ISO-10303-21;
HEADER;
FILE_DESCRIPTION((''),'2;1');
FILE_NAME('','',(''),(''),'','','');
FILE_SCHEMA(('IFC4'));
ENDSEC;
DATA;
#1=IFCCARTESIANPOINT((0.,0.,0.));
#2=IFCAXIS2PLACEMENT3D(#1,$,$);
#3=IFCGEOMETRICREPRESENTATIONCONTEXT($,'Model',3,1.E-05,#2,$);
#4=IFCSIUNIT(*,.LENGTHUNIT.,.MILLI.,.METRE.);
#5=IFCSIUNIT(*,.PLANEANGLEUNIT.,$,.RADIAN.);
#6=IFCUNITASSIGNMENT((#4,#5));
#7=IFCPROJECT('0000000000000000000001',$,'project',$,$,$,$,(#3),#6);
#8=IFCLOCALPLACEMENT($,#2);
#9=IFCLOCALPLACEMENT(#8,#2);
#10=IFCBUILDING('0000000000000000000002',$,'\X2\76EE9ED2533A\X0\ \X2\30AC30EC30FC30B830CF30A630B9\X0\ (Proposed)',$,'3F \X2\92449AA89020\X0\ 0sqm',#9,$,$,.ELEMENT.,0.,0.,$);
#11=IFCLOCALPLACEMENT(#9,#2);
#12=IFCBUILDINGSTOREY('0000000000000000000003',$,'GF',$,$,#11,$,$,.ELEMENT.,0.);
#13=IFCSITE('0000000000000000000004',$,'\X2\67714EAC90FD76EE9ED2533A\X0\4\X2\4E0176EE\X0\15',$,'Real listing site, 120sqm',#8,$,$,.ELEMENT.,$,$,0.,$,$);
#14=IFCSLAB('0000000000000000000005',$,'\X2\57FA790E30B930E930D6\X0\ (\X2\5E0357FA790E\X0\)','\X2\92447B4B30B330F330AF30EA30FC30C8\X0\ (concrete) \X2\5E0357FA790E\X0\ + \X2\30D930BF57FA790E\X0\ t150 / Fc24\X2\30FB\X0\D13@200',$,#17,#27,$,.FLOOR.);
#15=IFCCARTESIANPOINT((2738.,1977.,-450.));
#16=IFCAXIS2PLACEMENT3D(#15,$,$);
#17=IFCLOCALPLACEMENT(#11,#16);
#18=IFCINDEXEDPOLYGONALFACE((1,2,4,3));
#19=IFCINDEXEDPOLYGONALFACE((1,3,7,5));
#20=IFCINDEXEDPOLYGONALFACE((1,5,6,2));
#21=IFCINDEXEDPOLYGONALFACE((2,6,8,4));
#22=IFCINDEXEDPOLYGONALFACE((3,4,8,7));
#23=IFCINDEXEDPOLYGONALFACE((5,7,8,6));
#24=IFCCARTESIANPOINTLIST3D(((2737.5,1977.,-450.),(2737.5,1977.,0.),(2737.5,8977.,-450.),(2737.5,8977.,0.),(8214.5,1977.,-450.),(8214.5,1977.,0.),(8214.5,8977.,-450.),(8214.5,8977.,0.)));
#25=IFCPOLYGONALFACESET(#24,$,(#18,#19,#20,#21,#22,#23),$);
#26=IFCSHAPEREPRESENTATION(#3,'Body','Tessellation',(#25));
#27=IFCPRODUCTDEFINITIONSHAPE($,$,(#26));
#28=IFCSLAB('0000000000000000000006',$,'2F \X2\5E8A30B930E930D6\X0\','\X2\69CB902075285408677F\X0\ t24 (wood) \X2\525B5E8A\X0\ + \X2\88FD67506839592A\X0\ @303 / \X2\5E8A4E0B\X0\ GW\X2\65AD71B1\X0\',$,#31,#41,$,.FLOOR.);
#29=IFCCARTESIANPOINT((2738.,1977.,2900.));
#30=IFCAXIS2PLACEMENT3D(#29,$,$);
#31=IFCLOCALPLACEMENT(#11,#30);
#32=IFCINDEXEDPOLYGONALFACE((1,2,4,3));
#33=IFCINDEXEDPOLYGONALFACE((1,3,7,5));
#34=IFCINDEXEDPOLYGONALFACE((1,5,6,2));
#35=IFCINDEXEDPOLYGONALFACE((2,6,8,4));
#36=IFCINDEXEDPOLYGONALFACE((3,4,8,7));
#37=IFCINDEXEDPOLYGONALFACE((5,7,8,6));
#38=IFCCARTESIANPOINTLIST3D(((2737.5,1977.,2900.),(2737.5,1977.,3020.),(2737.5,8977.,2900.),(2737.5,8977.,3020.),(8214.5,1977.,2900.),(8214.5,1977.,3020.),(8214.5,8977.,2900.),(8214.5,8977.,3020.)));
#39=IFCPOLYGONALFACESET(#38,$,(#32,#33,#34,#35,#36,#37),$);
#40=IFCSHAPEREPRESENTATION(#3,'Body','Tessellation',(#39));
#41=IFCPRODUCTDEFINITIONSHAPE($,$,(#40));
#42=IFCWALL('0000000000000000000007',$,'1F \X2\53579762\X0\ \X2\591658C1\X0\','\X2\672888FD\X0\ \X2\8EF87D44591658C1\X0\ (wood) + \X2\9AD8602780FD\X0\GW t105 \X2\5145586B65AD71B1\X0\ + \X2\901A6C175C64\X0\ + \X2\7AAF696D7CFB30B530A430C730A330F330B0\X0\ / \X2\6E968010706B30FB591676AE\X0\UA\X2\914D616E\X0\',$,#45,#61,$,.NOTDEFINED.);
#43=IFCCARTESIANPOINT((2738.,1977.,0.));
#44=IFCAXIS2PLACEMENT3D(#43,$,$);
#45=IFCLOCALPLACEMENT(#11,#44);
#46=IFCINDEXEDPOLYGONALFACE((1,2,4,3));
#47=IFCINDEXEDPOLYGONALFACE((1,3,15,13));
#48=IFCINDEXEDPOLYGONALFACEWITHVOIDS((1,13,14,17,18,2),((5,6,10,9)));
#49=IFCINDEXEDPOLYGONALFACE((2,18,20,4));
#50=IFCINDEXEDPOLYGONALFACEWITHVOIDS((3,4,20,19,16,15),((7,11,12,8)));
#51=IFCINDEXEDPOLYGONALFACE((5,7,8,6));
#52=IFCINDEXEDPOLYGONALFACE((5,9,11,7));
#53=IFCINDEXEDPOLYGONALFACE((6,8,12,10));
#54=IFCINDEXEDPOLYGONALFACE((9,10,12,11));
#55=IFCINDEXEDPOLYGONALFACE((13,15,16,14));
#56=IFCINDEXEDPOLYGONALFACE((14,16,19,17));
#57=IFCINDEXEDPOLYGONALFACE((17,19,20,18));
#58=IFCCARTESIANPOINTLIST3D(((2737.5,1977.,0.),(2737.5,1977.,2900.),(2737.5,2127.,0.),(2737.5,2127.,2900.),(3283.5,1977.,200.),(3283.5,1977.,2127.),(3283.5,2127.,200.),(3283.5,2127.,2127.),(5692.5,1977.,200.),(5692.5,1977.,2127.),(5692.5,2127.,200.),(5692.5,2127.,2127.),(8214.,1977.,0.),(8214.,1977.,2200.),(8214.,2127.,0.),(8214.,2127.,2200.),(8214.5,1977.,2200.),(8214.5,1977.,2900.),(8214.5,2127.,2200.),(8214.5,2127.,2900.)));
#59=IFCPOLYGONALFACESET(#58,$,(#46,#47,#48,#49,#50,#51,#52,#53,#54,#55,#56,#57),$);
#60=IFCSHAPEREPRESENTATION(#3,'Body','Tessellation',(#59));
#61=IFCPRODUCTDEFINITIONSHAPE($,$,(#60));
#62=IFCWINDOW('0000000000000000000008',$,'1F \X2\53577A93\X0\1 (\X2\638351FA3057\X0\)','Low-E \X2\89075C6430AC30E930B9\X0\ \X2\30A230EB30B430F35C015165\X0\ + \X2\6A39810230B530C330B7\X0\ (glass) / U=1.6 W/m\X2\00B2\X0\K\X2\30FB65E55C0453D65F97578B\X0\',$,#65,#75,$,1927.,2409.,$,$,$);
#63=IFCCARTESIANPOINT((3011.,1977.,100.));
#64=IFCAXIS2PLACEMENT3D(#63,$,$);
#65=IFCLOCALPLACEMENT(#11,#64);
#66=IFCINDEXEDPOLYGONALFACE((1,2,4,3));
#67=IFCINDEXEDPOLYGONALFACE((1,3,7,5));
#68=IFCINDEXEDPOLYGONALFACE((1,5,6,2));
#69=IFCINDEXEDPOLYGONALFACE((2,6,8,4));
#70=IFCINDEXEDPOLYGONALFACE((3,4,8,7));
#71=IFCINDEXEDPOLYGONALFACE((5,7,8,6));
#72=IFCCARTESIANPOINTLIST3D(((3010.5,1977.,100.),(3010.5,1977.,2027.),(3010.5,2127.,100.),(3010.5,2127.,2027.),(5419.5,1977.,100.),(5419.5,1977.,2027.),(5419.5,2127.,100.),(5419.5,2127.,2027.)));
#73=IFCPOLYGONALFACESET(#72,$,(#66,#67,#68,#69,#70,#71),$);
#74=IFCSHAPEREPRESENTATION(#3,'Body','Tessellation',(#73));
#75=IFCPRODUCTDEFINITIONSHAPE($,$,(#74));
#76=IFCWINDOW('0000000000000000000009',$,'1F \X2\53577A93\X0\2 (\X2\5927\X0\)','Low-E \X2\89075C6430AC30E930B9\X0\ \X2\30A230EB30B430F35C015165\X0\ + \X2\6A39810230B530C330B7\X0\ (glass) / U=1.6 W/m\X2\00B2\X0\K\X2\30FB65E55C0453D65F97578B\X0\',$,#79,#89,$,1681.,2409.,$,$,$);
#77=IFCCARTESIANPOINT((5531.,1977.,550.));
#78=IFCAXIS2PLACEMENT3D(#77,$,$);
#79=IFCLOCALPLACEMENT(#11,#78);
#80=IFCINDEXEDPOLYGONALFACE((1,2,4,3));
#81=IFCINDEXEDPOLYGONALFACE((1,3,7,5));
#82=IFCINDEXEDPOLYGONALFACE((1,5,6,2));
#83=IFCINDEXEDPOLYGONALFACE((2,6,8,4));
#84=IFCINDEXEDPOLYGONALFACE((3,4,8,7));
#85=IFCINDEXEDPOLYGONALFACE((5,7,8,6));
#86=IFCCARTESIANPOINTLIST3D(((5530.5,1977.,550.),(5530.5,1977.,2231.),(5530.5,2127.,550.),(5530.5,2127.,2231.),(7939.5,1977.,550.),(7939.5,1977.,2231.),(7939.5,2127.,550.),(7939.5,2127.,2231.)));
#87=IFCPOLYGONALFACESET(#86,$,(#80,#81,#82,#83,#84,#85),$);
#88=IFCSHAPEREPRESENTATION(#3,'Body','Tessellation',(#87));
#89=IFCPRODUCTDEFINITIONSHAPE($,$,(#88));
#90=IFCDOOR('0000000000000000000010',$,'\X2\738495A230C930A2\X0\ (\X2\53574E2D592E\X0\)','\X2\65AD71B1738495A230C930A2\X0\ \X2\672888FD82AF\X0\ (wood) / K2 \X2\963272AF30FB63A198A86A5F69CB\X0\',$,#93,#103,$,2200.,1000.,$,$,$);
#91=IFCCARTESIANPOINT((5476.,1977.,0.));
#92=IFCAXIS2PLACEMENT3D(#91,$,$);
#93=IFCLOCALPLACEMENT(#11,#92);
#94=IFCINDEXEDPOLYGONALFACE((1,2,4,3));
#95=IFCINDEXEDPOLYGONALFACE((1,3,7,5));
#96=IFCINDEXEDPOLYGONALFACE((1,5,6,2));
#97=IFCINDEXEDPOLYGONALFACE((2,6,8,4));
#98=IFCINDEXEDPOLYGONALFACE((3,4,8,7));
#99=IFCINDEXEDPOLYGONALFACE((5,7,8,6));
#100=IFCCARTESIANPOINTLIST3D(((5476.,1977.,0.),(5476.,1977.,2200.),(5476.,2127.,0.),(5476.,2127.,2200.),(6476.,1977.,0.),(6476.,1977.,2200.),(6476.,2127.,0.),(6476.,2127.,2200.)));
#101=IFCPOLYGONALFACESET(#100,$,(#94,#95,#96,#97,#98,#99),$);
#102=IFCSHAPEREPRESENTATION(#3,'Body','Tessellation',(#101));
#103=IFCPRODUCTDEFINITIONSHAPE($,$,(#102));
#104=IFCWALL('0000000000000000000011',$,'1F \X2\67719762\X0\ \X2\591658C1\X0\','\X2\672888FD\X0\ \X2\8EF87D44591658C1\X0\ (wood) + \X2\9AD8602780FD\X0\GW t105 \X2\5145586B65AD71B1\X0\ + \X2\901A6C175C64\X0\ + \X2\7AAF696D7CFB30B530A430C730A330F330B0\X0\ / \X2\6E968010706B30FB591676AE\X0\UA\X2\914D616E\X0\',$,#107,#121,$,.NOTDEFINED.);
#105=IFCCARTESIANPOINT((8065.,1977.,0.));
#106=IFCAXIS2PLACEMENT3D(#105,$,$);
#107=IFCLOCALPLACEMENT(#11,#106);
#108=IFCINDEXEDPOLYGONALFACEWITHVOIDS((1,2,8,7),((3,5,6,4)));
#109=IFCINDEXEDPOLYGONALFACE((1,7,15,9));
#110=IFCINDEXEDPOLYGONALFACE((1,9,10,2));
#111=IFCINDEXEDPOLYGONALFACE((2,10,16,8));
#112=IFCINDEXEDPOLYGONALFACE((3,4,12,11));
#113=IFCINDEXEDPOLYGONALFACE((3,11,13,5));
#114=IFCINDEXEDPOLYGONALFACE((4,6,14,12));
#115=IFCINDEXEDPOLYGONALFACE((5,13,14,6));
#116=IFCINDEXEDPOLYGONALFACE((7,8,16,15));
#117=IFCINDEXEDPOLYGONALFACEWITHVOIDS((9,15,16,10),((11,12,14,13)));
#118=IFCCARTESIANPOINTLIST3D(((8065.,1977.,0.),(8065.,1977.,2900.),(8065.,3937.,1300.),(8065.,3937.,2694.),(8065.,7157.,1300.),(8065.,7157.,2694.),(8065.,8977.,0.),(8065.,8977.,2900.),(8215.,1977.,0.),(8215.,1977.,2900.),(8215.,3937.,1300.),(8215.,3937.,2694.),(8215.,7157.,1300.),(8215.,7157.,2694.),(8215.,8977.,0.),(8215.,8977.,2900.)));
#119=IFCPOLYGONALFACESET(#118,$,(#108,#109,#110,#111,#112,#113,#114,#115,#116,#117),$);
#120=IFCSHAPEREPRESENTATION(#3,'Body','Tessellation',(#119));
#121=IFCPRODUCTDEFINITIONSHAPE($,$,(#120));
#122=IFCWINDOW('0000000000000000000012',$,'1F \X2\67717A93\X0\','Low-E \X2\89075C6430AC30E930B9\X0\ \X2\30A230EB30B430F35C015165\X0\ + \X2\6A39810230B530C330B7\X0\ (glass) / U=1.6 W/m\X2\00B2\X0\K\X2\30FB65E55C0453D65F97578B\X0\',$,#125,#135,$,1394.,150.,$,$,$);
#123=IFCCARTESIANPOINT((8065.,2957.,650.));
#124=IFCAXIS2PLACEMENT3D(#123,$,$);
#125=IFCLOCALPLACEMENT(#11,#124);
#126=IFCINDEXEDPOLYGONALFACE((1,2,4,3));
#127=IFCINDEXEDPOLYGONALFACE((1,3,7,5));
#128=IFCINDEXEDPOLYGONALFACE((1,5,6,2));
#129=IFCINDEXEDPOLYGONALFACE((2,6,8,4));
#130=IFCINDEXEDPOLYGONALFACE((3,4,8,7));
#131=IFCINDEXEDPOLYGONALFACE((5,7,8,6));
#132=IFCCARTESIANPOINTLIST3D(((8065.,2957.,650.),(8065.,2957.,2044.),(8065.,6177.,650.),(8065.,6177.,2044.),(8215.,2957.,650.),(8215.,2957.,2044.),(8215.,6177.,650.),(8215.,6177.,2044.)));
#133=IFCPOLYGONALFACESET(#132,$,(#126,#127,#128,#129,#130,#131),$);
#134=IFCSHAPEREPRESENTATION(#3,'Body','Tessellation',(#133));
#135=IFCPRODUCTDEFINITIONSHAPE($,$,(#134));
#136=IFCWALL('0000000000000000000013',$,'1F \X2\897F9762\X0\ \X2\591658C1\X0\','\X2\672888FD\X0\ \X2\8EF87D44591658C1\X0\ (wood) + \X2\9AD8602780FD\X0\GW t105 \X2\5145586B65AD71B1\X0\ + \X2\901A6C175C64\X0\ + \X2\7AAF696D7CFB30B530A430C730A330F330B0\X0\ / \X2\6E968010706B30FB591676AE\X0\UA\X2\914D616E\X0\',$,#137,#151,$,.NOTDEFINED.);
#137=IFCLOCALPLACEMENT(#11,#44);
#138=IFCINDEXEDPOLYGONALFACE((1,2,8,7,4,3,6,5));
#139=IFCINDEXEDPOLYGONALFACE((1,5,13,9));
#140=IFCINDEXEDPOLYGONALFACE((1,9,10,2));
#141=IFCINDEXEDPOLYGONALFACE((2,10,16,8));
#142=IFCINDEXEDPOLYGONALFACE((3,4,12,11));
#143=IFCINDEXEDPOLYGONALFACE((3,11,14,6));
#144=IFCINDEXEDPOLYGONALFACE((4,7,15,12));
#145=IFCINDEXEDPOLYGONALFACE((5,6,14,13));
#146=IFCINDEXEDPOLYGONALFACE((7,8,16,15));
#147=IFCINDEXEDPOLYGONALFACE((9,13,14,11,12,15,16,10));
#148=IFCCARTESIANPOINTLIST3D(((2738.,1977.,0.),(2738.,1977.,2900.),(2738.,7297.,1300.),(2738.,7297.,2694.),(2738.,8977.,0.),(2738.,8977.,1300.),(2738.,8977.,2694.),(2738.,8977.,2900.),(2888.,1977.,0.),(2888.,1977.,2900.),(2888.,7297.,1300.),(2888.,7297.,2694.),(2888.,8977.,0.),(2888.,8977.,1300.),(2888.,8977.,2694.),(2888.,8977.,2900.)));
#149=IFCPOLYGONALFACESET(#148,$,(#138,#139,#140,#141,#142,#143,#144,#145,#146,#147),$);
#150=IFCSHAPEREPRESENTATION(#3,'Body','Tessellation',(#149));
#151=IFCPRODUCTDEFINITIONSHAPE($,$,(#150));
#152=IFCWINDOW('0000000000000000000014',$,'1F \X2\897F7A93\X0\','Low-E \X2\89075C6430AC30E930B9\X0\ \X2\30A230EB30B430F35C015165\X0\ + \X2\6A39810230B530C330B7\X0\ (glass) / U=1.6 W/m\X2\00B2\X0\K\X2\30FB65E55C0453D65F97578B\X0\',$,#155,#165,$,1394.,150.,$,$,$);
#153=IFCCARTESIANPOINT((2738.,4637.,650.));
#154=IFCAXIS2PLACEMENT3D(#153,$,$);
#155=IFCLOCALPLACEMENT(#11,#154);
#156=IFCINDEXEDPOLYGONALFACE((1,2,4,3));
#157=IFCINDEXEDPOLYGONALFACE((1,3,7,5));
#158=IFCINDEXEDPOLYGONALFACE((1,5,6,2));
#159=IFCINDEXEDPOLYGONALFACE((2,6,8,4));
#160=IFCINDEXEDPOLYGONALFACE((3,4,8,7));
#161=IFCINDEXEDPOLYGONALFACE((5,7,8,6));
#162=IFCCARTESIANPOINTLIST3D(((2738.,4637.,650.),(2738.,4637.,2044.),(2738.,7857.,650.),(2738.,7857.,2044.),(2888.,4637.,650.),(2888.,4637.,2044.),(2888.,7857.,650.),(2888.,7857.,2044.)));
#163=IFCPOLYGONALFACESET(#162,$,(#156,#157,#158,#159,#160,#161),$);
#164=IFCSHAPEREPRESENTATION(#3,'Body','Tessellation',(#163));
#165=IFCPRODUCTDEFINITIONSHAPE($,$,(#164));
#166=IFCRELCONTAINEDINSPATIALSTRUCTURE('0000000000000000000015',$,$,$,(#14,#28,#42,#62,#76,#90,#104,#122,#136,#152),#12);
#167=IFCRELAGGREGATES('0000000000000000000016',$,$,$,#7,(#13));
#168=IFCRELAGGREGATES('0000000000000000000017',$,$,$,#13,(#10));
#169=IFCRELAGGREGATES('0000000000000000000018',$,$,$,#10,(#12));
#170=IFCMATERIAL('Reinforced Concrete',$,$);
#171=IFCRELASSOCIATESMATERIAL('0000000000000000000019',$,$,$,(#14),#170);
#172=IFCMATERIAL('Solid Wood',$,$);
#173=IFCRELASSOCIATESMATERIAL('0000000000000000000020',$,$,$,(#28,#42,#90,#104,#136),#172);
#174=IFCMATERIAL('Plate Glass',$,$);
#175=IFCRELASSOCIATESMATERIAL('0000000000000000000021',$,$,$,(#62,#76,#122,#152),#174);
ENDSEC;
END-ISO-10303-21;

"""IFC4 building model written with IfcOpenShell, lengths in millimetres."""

from ifc_helpers import new_model, si_unit, frame, frame_2d, origin, place, context, project, spatial, rectangle, extrude, material, element, fill, save


model = new_model("IFC4")

# Units and contexts
model_context = context("Model", 3, precision=1e-05, world=origin())
ifc_project = project(units=[si_unit("LENGTHUNIT", "METRE", prefix="MILLI"), si_unit("PLANEANGLEUNIT", "RADIAN")], contexts=[model_context])

# Site, building, storey
site_placement = place(None, origin())
site = spatial("IfcSite", under=ifc_project, at=site_placement, Name="東京都目黒区4丁目15", ObjectType="Real listing site, 120sqm", CompositionType="ELEMENT", RefElevation=0.0)
building_placement = place(site_placement, origin())
building = spatial("IfcBuilding", under=site, at=building_placement, Name="目黒区 ガレージハウス (Proposed)", ObjectType="3F 鉄骨造 0sqm", CompositionType="ELEMENT", ElevationOfRefHeight=0.0, ElevationOfTerrain=0.0)
storey_placement = place(building_placement, origin())
storey = spatial("IfcBuildingStorey", under=building, at=storey_placement, Name="GF", CompositionType="ELEMENT", Elevation=0.0)

# Slabs
ifc_material_1 = material(Name="Reinforced Concrete")
slab_1_placement = place(storey_placement, frame((2738.0, 1977.0, -450.0)))
element("IfcSlab", 1, at=slab_1_placement, inside=storey, material=ifc_material_1, Name="基礎スラブ (布基礎)", Description="鉄筋コンクリート (concrete) 布基礎 + ベタ基礎 t150 / Fc24・D13@200", PredefinedType="FLOOR", context=model_context, shape_type="SweptSolid", body=[
    extrude(rectangle(XDim=5477.0, YDim=7000.0, at=frame_2d((2738.0, 3500.0))), frame((2738.0, 1977.0, -450.0)), (0.0, 0.0, 1.0), 450.0),
])
ifc_material_2 = material(Name="Solid Wood")
slab_2_placement = place(storey_placement, frame((2738.0, 1977.0, 2900.0)))
element("IfcSlab", 2, at=slab_2_placement, inside=storey, material=ifc_material_2, Name="2F 床スラブ", Description="構造用合板 t24 (wood) 剛床 + 製材根太 @303 / 床下 GW断熱", PredefinedType="FLOOR", context=model_context, shape_type="SweptSolid", body=[
    extrude(rectangle(XDim=5477.0, YDim=7000.0, at=frame_2d((2738.0, 3500.0))), frame((2738.0, 1977.0, 2900.0)), (0.0, 0.0, 1.0), 120.0),
])

# Wall, openings, windows, door
wall_1_placement = place(storey_placement, frame((2738.0, 1977.0, 0.0)))
wall_1 = element("IfcWall", 3, at=wall_1_placement, inside=storey, material=ifc_material_2, Name="1F 南面 外壁", Description="木製 軸組外壁 (wood) + 高性能GW t105 充填断熱 + 通気層 + 窯業系サイディング / 準耐火・外皮UA配慮", PredefinedType="NOTDEFINED", context=model_context, shape_type="SweptSolid", body=[
    extrude(rectangle(XDim=5477.0, YDim=150.0, at=frame_2d((2738.0, 75.0))), frame((2738.0, 1977.0, 0.0)), (0.0, 0.0, 1.0), 2900.0),
])
opening_1_placement = place(storey_placement, frame((3011.0, 1977.0, 100.0)))
opening_1 = element("IfcOpeningElement", 4, at=opening_1_placement, cuts=wall_1, PredefinedType="NOTDEFINED", context=model_context, shape_type="SweptSolid", body=[
    extrude(rectangle(XDim=2409.0, YDim=150.0, at=frame_2d((1204.0, 75.0))), frame((3011.0, 1977.0, 100.0)), (0.0, 0.0, 1.0), 1927.0),
])
opening_2_placement = place(storey_placement, frame((5531.0, 1977.0, 550.0)))
opening_2 = element("IfcOpeningElement", 5, at=opening_2_placement, cuts=wall_1, PredefinedType="NOTDEFINED", context=model_context, shape_type="SweptSolid", body=[
    extrude(rectangle(XDim=2409.0, YDim=150.0, at=frame_2d((1204.0, 75.0))), frame((5531.0, 1977.0, 550.0)), (0.0, 0.0, 1.0), 1681.0),
])
opening_3_placement = place(storey_placement, frame((5476.0, 1977.0, 0.0)))
opening_3 = element("IfcOpeningElement", 6, at=opening_3_placement, cuts=wall_1, PredefinedType="NOTDEFINED", context=model_context, shape_type="SweptSolid", body=[
    extrude(rectangle(XDim=1000.0, YDim=150.0, at=frame_2d((500.0, 75.0))), frame((5476.0, 1977.0, 0.0)), (0.0, 0.0, 1.0), 2200.0),
])
ifc_material_3 = material(Name="Plate Glass")
window_1_placement = place(storey_placement, frame((3011.0, 1977.0, 100.0)))
window_1 = element("IfcWindow", 7, at=window_1_placement, inside=storey, material=ifc_material_3, Name="1F 南窓1 (掃出し)", Description="Low-E 複層ガラス アルゴン封入 + 樹脂サッシ (glass) / U=1.6 W/m²K・日射取得型", OverallHeight=1927.0, OverallWidth=2409.0, context=model_context, shape_type="SweptSolid", body=[
    extrude(rectangle(XDim=2409.0, YDim=150.0, at=frame_2d((1204.0, 75.0))), frame((3011.0, 1977.0, 100.0)), (0.0, 0.0, 1.0), 1927.0),
])
fill(opening_1, window_1)
window_2_placement = place(storey_placement, frame((5531.0, 1977.0, 550.0)))
window_2 = element("IfcWindow", 8, at=window_2_placement, inside=storey, material=ifc_material_3, Name="1F 南窓2 (大)", Description="Low-E 複層ガラス アルゴン封入 + 樹脂サッシ (glass) / U=1.6 W/m²K・日射取得型", OverallHeight=1681.0, OverallWidth=2409.0, context=model_context, shape_type="SweptSolid", body=[
    extrude(rectangle(XDim=2409.0, YDim=150.0, at=frame_2d((1204.0, 75.0))), frame((5531.0, 1977.0, 550.0)), (0.0, 0.0, 1.0), 1681.0),
])
fill(opening_2, window_2)
door_placement = place(storey_placement, frame((5476.0, 1977.0, 0.0)))
door = element("IfcDoor", 9, at=door_placement, inside=storey, material=ifc_material_2, Name="玄関ドア (南中央)", Description="断熱玄関ドア 木製芯 (wood) / K2 防犯・採風機構", OverallHeight=2200.0, OverallWidth=1000.0, context=model_context, shape_type="SweptSolid", body=[
    extrude(rectangle(XDim=1000.0, YDim=150.0, at=frame_2d((500.0, 75.0))), frame((5476.0, 1977.0, 0.0)), (0.0, 0.0, 1.0), 2200.0),
])
fill(opening_3, door)

# Walls, openings, windows
wall_2_placement = place(storey_placement, frame((8065.0, 1977.0, 0.0)))
wall_2 = element("IfcWall", 10, at=wall_2_placement, inside=storey, material=ifc_material_2, Name="1F 東面 外壁", Description="木製 軸組外壁 (wood) + 高性能GW t105 充填断熱 + 通気層 + 窯業系サイディング / 準耐火・外皮UA配慮", PredefinedType="NOTDEFINED", context=model_context, shape_type="SweptSolid", body=[
    extrude(rectangle(XDim=150.0, YDim=7000.0, at=frame_2d((75.0, 3500.0))), frame((8065.0, 1977.0, 0.0)), (0.0, 0.0, 1.0), 2900.0),
])
opening_4_placement = place(storey_placement, frame((8065.0, 2957.0, 650.0)))
opening_4 = element("IfcOpeningElement", 11, at=opening_4_placement, cuts=wall_2, PredefinedType="NOTDEFINED", context=model_context, shape_type="SweptSolid", body=[
    extrude(rectangle(XDim=150.0, YDim=3220.0, at=frame_2d((75.0, 1610.0))), frame((8065.0, 2957.0, 650.0)), (0.0, 0.0, 1.0), 1394.0),
])
window_3_placement = place(storey_placement, frame((8065.0, 2957.0, 650.0)))
window_3 = element("IfcWindow", 12, at=window_3_placement, inside=storey, material=ifc_material_3, Name="1F 東窓", Description="Low-E 複層ガラス アルゴン封入 + 樹脂サッシ (glass) / U=1.6 W/m²K・日射取得型", OverallHeight=1394.0, OverallWidth=150.0, context=model_context, shape_type="SweptSolid", body=[
    extrude(rectangle(XDim=150.0, YDim=3220.0, at=frame_2d((75.0, 1610.0))), frame((8065.0, 2957.0, 650.0)), (0.0, 0.0, 1.0), 1394.0),
])
fill(opening_4, window_3)
wall_3_placement = place(storey_placement, frame((2738.0, 1977.0, 0.0)))
wall_3 = element("IfcWall", 13, at=wall_3_placement, inside=storey, material=ifc_material_2, Name="1F 西面 外壁", Description="木製 軸組外壁 (wood) + 高性能GW t105 充填断熱 + 通気層 + 窯業系サイディング / 準耐火・外皮UA配慮", PredefinedType="NOTDEFINED", context=model_context, shape_type="SweptSolid", body=[
    extrude(rectangle(XDim=150.0, YDim=7000.0, at=frame_2d((75.0, 3500.0))), frame((2738.0, 1977.0, 0.0)), (0.0, 0.0, 1.0), 2900.0),
])
opening_5_placement = place(storey_placement, frame((2738.0, 4637.0, 650.0)))
opening_5 = element("IfcOpeningElement", 14, at=opening_5_placement, cuts=wall_3, PredefinedType="NOTDEFINED", context=model_context, shape_type="SweptSolid", body=[
    extrude(rectangle(XDim=150.0, YDim=3220.0, at=frame_2d((75.0, 1610.0))), frame((2738.0, 4637.0, 650.0)), (0.0, 0.0, 1.0), 1394.0),
])
window_4_placement = place(storey_placement, frame((2738.0, 4637.0, 650.0)))
window_4 = element("IfcWindow", 15, at=window_4_placement, inside=storey, material=ifc_material_3, Name="1F 西窓", Description="Low-E 複層ガラス アルゴン封入 + 樹脂サッシ (glass) / U=1.6 W/m²K・日射取得型", OverallHeight=1394.0, OverallWidth=150.0, context=model_context, shape_type="SweptSolid", body=[
    extrude(rectangle(XDim=150.0, YDim=3220.0, at=frame_2d((75.0, 1610.0))), frame((2738.0, 4637.0, 650.0)), (0.0, 0.0, 1.0), 1394.0),
])
fill(opening_5, window_4)

save(model, "model.ifc")
